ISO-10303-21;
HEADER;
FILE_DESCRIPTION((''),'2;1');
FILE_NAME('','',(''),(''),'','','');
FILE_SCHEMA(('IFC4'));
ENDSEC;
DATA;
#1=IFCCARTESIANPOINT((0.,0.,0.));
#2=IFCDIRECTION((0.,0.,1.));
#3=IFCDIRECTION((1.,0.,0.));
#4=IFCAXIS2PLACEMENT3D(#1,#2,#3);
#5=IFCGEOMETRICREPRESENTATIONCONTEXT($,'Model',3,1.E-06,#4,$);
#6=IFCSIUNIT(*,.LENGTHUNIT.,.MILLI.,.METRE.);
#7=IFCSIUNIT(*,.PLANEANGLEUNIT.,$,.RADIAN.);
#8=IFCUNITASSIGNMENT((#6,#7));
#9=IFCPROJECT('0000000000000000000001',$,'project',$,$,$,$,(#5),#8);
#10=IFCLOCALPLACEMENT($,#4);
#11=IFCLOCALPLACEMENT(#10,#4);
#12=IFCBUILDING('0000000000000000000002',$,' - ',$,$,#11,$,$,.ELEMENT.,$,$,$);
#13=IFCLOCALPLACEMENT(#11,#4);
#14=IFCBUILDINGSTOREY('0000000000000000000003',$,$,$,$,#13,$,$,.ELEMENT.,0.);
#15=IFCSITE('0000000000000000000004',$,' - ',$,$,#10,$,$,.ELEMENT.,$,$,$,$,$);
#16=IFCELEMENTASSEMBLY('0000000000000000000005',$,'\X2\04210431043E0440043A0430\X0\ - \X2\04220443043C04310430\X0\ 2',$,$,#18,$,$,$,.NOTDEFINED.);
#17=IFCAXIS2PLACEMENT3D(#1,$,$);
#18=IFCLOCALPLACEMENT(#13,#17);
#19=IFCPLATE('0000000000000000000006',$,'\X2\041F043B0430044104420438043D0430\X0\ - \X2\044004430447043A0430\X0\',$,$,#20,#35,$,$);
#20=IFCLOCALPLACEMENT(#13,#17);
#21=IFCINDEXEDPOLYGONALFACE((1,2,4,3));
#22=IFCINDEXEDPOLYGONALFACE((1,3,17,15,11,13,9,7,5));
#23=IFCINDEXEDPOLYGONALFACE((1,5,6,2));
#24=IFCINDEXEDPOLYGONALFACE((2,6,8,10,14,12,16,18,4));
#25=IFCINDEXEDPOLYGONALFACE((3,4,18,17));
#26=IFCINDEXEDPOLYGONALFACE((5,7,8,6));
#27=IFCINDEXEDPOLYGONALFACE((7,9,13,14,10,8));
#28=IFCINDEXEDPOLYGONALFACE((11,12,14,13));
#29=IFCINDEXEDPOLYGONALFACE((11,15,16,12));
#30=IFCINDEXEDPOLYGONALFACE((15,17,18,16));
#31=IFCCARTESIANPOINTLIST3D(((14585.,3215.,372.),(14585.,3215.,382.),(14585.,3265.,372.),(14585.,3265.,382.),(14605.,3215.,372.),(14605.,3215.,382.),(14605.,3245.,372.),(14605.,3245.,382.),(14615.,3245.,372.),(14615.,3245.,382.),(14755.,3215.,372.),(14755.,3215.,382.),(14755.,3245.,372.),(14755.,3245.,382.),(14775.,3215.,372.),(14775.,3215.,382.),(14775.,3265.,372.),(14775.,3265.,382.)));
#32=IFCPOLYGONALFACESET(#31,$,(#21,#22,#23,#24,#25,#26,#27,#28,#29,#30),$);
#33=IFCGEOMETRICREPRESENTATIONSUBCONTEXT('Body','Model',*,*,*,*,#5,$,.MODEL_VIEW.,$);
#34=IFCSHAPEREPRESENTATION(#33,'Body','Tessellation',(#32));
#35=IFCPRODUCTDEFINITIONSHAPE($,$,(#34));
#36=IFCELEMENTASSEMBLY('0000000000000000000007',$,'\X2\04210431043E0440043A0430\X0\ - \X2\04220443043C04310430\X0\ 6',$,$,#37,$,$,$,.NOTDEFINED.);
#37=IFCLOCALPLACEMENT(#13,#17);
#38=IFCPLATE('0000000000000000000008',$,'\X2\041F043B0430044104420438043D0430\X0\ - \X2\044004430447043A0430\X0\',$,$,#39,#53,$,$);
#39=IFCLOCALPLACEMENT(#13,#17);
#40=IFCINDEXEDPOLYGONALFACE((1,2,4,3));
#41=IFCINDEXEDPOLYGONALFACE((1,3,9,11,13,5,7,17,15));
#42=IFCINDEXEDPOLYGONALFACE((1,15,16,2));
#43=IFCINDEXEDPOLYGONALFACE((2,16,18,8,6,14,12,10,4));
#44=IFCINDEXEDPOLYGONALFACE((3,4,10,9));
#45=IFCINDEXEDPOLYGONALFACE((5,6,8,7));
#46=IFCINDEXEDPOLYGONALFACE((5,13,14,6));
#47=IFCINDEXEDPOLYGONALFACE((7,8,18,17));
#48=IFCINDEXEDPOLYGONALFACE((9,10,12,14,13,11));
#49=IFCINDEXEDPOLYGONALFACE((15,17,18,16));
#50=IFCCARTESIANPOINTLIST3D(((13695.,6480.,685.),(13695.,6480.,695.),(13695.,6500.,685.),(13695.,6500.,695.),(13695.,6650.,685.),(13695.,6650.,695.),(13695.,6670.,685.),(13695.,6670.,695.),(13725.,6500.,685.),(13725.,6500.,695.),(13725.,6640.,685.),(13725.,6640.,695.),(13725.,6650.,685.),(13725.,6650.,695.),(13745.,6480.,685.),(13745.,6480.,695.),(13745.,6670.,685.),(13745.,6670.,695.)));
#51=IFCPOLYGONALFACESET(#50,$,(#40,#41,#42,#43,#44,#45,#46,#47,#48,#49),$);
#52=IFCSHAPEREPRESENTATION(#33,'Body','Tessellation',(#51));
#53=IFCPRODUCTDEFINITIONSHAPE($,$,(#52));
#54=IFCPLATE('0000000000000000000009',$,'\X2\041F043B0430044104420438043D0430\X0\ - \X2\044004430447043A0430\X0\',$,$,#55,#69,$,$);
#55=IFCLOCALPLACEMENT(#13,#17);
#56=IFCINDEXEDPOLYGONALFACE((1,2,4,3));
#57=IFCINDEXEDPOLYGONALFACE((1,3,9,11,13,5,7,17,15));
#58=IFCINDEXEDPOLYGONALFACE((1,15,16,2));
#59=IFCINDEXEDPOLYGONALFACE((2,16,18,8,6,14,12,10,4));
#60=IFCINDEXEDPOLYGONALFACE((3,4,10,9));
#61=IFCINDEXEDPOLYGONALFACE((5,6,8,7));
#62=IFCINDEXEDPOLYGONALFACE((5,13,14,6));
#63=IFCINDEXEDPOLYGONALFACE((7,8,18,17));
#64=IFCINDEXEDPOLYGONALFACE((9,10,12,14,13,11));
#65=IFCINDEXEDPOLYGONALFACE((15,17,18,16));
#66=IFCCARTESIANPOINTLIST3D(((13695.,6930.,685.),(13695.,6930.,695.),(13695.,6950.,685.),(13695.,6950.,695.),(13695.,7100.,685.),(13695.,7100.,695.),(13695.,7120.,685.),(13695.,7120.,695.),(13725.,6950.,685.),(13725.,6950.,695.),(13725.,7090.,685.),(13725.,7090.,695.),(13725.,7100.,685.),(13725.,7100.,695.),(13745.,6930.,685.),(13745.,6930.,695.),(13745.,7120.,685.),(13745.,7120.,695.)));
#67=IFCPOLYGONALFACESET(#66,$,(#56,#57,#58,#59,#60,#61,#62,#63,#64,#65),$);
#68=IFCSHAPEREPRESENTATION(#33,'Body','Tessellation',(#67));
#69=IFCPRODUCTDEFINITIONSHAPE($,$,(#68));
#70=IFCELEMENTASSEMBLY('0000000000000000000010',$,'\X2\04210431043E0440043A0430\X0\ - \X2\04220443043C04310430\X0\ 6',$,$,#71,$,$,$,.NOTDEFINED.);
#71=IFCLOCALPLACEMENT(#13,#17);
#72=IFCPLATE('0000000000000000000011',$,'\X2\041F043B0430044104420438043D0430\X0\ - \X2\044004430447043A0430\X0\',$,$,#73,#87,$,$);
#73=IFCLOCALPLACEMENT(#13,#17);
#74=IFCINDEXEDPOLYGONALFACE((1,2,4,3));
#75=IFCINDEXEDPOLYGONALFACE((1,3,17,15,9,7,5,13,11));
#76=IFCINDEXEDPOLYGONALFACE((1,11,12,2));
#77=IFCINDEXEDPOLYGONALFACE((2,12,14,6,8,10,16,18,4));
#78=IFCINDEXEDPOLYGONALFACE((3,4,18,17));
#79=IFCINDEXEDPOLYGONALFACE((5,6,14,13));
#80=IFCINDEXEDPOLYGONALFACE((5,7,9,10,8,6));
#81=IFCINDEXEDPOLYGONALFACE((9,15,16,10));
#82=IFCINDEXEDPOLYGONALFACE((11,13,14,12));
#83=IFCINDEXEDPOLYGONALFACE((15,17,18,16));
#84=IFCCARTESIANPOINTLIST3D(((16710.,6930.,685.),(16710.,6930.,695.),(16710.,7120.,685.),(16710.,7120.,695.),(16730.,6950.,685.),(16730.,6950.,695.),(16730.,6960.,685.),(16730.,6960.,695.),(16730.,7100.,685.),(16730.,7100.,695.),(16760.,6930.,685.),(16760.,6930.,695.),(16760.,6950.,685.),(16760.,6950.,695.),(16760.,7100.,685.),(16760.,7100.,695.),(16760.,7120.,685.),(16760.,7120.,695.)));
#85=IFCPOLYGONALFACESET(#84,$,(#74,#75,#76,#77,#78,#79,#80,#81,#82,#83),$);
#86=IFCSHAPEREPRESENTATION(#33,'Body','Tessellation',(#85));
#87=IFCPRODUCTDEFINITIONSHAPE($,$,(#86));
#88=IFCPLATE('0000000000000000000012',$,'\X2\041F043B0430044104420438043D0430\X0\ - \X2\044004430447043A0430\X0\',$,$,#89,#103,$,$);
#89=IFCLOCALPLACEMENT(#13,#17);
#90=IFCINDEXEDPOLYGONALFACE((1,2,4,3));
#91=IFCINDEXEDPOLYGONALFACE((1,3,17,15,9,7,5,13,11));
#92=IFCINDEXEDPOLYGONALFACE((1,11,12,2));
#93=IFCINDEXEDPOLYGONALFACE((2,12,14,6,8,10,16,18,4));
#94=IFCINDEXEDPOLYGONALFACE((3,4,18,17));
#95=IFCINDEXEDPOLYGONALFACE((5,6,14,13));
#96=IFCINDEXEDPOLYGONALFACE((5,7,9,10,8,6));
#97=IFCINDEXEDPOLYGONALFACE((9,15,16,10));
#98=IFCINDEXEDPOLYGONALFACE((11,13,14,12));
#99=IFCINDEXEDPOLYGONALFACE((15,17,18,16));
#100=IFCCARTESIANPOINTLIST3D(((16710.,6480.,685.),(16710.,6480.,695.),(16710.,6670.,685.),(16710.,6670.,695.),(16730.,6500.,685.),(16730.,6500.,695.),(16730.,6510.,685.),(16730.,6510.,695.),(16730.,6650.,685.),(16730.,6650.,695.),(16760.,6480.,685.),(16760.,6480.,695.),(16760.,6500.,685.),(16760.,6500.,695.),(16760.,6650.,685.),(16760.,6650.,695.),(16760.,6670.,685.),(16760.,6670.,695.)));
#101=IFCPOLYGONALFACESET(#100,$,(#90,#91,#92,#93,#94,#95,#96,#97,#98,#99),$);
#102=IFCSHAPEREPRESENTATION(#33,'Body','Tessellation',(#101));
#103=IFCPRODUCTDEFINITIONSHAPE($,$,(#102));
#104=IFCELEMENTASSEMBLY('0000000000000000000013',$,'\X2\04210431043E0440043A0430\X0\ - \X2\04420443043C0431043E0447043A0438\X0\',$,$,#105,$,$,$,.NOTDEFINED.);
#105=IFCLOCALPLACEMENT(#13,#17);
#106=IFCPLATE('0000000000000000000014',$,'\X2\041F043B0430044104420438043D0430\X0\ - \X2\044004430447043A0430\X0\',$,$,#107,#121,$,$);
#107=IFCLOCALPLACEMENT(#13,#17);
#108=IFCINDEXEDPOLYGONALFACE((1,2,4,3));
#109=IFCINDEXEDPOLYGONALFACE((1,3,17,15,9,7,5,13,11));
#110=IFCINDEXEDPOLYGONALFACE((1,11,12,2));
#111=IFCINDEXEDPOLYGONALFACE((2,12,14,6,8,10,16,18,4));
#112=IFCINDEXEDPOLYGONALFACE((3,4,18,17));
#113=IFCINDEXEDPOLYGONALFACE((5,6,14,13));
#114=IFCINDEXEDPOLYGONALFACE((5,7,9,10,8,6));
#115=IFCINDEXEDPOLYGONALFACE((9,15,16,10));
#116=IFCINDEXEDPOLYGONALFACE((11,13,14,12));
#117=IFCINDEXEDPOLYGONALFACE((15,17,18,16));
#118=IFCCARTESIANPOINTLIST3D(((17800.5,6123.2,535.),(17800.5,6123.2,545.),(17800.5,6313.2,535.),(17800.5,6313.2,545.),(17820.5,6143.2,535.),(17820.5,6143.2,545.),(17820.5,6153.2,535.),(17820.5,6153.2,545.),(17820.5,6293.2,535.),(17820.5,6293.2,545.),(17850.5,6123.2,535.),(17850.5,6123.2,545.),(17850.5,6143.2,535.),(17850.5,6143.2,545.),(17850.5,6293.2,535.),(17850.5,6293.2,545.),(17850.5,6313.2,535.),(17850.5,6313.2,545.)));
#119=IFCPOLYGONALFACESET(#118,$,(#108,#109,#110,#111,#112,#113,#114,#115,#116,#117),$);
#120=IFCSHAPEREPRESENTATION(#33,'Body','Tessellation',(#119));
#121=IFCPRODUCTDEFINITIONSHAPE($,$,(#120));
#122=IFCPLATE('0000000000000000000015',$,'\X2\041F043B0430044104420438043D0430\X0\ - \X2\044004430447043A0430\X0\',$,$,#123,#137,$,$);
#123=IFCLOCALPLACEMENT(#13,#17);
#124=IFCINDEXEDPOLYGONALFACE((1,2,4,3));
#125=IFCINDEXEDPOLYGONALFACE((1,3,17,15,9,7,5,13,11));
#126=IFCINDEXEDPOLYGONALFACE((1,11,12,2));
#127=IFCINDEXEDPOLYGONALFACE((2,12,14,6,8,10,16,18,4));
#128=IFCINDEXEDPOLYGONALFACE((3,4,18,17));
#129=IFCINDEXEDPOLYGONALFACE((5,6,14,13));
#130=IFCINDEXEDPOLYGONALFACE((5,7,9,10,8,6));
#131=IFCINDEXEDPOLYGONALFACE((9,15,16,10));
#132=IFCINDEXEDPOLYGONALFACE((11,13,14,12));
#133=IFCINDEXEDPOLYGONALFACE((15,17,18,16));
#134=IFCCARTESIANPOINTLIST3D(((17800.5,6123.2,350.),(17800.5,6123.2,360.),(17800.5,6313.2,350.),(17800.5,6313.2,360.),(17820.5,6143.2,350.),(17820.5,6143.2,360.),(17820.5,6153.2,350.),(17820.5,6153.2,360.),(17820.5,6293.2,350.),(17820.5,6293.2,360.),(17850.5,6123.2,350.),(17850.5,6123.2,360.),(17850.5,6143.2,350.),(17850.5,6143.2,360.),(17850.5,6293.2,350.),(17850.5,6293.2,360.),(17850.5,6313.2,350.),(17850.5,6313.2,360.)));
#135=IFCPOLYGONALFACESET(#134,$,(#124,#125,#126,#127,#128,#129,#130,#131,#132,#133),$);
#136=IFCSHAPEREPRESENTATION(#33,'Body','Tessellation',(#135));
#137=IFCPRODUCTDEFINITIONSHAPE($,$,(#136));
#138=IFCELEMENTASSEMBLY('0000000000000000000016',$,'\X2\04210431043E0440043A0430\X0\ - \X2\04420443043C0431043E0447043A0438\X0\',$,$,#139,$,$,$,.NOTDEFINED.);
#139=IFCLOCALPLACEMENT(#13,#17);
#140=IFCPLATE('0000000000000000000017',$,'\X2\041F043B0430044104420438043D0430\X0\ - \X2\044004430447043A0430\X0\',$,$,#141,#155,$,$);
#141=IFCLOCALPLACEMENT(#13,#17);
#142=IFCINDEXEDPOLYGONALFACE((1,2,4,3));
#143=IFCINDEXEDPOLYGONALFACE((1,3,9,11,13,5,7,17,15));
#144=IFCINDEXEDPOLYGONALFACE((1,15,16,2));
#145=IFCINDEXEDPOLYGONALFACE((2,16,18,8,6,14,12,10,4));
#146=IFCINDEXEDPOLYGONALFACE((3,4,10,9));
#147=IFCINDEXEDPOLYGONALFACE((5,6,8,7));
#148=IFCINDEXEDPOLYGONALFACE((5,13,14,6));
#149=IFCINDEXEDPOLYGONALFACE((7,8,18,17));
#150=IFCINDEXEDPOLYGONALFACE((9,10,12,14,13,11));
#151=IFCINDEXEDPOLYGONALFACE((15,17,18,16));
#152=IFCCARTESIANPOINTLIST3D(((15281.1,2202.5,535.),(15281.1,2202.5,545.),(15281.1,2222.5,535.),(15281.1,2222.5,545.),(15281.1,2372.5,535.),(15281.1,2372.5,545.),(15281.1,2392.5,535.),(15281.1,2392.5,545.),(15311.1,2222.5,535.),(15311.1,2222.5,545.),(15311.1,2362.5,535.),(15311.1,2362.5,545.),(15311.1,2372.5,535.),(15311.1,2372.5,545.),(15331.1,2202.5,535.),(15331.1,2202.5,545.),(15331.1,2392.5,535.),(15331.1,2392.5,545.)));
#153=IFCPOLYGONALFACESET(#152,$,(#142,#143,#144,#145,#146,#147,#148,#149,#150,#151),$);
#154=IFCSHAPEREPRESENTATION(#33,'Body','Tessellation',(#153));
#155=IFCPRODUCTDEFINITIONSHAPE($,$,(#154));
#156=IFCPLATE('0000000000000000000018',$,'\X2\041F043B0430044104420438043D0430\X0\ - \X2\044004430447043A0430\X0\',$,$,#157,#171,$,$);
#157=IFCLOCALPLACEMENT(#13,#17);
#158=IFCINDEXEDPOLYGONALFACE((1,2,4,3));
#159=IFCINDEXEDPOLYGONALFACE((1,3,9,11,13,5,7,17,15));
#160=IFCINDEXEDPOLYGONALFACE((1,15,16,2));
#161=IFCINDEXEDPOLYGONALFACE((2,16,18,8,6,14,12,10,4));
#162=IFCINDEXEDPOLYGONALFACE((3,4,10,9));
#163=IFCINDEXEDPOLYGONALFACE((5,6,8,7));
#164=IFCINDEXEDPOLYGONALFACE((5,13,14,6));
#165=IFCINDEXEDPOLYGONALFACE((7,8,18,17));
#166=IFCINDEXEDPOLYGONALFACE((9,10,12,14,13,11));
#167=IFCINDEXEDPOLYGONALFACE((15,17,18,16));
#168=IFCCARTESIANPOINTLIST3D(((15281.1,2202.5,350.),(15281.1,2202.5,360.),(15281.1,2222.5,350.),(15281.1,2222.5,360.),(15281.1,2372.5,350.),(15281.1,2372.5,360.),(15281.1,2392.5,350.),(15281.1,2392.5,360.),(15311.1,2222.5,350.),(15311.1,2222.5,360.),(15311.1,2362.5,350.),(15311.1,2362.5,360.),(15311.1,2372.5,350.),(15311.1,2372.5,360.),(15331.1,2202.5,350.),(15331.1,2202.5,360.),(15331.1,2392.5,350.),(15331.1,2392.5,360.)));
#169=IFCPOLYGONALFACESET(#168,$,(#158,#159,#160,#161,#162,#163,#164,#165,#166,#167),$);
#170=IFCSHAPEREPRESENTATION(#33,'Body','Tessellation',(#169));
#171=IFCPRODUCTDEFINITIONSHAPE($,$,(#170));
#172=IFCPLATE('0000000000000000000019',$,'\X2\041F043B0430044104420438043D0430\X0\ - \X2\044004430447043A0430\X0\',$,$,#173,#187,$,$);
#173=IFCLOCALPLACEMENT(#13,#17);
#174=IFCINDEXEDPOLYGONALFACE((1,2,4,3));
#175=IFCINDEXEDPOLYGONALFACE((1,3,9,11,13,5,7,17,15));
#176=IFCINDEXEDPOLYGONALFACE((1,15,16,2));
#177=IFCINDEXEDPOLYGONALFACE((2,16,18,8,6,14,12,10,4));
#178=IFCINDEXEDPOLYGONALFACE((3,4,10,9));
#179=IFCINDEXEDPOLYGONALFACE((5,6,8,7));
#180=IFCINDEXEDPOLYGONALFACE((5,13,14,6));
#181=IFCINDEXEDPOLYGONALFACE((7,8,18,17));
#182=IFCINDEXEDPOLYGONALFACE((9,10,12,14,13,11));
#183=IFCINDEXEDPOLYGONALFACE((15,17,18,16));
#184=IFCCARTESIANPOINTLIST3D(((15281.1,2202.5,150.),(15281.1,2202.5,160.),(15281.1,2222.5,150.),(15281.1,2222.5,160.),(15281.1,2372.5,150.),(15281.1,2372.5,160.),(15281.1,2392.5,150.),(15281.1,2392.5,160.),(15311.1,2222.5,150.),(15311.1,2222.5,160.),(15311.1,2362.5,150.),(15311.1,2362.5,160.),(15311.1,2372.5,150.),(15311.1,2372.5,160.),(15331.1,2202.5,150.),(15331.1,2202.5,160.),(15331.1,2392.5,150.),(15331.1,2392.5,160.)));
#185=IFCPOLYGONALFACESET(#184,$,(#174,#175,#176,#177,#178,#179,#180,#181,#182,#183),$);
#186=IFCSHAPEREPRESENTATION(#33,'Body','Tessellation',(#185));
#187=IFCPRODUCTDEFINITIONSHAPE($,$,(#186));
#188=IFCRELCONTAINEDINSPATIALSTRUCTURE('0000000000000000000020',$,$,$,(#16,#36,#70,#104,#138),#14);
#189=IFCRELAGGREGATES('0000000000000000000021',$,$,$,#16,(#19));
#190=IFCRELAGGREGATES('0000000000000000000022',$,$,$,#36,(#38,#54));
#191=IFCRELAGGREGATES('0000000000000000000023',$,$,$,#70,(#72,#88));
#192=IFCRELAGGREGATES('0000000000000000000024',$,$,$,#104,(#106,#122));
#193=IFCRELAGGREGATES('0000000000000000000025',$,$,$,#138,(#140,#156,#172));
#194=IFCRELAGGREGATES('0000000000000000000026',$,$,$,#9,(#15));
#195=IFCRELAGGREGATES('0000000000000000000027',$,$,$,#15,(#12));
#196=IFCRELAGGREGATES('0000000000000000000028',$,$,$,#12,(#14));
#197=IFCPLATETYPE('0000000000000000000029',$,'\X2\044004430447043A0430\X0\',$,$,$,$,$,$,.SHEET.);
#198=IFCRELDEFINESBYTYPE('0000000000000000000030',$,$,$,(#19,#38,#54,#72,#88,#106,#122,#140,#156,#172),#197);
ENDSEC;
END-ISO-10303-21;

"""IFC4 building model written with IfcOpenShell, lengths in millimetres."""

from ifc_helpers import new_model, si_unit, frame, origin_with_axes, place, context, subcontext, project, spatial, line, indexed_curve, outline, extrude, source, transform, mapped, type_object, element, aggregate, save


model = new_model("IFC4")

# Units and contexts
model_context = context("Model", 3, precision=1e-06, world=origin_with_axes())
body_context = subcontext(model_context, "Body", "Model", "MODEL_VIEW")
ifc_project = project(units=[si_unit("LENGTHUNIT", "METRE", prefix="MILLI"), si_unit("PLANEANGLEUNIT", "RADIAN")], contexts=[model_context])

# Site, building, storey
site_placement = place(None, origin_with_axes())
site = spatial("IfcSite", under=ifc_project, at=site_placement, Name=" - ", CompositionType="ELEMENT")
building_placement = place(site_placement, origin_with_axes())
building = spatial("IfcBuilding", under=site, at=building_placement, Name=" - ", CompositionType="ELEMENT")
storey_placement = place(building_placement, origin_with_axes())
storey = spatial("IfcBuildingStorey", under=building, at=storey_placement, CompositionType="ELEMENT", Elevation=0.0)

# Element assembly, plate
assembly_1_placement = place(storey_placement, frame((14680.0, 3000.0, 2.0), z_axis=(0.0, 0.0, 1.0), x_axis=(-1.0, 0.0, 0.0)))
assembly_1 = element("IfcElementAssembly", 1, at=assembly_1_placement, inside=storey, Name="Сборка - Тумба 2", PredefinedType="NOTDEFINED")
plate_type = type_object("IfcPlateType", Name="ручка", PredefinedType="SHEET")
shared_shape = source(origin_with_axes(), body_context, "Body", "SweptSolid", [
    extrude(outline(indexed_curve([(-95.0, -25.0), (-75.0, -25.0), (-75.0, 5.0), (-65.0, 5.0), (75.0, 5.0), (75.0, -25.0), (95.0, -25.0), (95.0, 25.0), (-95.0, 25.0)], segments=[line(1, 2), line(2, 3), line(3, 4), line(4, 5), line(5, 6), line(6, 7), line(7, 8), line(8, 9), line(9, 1)])), origin_with_axes(), (0.0, 0.0, 1.0), 10.0),
])
plate_1_placement = place(assembly_1_placement, frame((0.0, -240.0, 370.0), z_axis=(0.0, 0.0, 1.0), x_axis=(-1.0, 0.0, 0.0)))
plate_1 = element("IfcPlate", 2, at=plate_1_placement, type_object=plate_type, Name="Пластина - ручка", context=body_context, shape_type="MappedRepresentation", body=[
    mapped(shared_shape, transform((0.0, 0.0, 0.0), x_axis=(1.0, 0.0, 0.0), y_axis=(0.0, 1.0, 0.0), z_axis=(0.0, 0.0, 1.0), scale=1.0)),
])
aggregate(assembly_1, [plate_1])

# Element assemblies, plates
assembly_2_placement = place(storey_placement, frame((13680.0, 6350.0, 0.0), z_axis=(0.0, 0.0, 1.0), x_axis=(0.0, 1.0, 0.0)))
assembly_2 = element("IfcElementAssembly", 3, at=assembly_2_placement, inside=storey, Name="Сборка - Тумба 6", PredefinedType="NOTDEFINED")
plate_2_placement = place(assembly_2_placement, frame((225.0, -40.0, 685.0), z_axis=(0.0, 0.0, 1.0), x_axis=(-1.0, 0.0, 0.0)))
plate_2 = element("IfcPlate", 4, at=plate_2_placement, type_object=plate_type, Name="Пластина - ручка", context=body_context, shape_type="MappedRepresentation", body=[
    mapped(shared_shape, transform((0.0, 0.0, 0.0), x_axis=(1.0, 0.0, 0.0), y_axis=(0.0, 1.0, 0.0), z_axis=(0.0, 0.0, 1.0), scale=1.0)),
])
plate_3_placement = place(assembly_2_placement, frame((675.0, -40.0, 685.0), z_axis=(0.0, 0.0, 1.0), x_axis=(-1.0, 0.0, 0.0)))
plate_3 = element("IfcPlate", 5, at=plate_3_placement, type_object=plate_type, Name="Пластина - ручка", context=body_context, shape_type="MappedRepresentation", body=[
    mapped(shared_shape, transform((0.0, 0.0, 0.0), x_axis=(1.0, 0.0, 0.0), y_axis=(0.0, 1.0, 0.0), z_axis=(0.0, 0.0, 1.0), scale=1.0)),
])
aggregate(assembly_2, [plate_2, plate_3])
assembly_3_placement = place(storey_placement, frame((16775.0, 7250.0, 0.0), z_axis=(0.0, 0.0, 1.0), x_axis=(0.0, -1.0, 0.0)))
assembly_3 = element("IfcElementAssembly", 6, at=assembly_3_placement, inside=storey, Name="Сборка - Тумба 6", PredefinedType="NOTDEFINED")
plate_4_placement = place(assembly_3_placement, frame((225.0, -40.0, 685.0), z_axis=(0.0, 0.0, 1.0), x_axis=(-1.0, 0.0, 0.0)))
plate_4 = element("IfcPlate", 7, at=plate_4_placement, type_object=plate_type, Name="Пластина - ручка", context=body_context, shape_type="MappedRepresentation", body=[
    mapped(shared_shape, transform((0.0, 0.0, 0.0), x_axis=(1.0, 0.0, 0.0), y_axis=(0.0, 1.0, 0.0), z_axis=(0.0, 0.0, 1.0), scale=1.0)),
])
plate_5_placement = place(assembly_3_placement, frame((675.0, -40.0, 685.0), z_axis=(0.0, 0.0, 1.0), x_axis=(-1.0, 0.0, 0.0)))
plate_5 = element("IfcPlate", 8, at=plate_5_placement, type_object=plate_type, Name="Пластина - ручка", context=body_context, shape_type="MappedRepresentation", body=[
    mapped(shared_shape, transform((0.0, 0.0, 0.0), x_axis=(1.0, 0.0, 0.0), y_axis=(0.0, 1.0, 0.0), z_axis=(0.0, 0.0, 1.0), scale=1.0)),
])
aggregate(assembly_3, [plate_4, plate_5])
assembly_4_placement = place(storey_placement, frame((17850.5, 6418.2, 0.0), z_axis=(0.0, 0.0, 1.0), x_axis=(0.0, -1.0, 0.0)))
assembly_4 = element("IfcElementAssembly", 9, at=assembly_4_placement, inside=storey, Name="Сборка - тумбочки", PredefinedType="NOTDEFINED")
plate_6_placement = place(assembly_4_placement, frame((200.0, -25.0, 535.0), z_axis=(0.0, 0.0, 1.0), x_axis=(-1.0, 0.0, 0.0)))
plate_6 = element("IfcPlate", 10, at=plate_6_placement, type_object=plate_type, Name="Пластина - ручка", context=body_context, shape_type="MappedRepresentation", body=[
    mapped(shared_shape, transform((0.0, 0.0, 0.0), x_axis=(1.0, 0.0, 0.0), y_axis=(0.0, 1.0, 0.0), z_axis=(0.0, 0.0, 1.0), scale=1.0)),
])
plate_7_placement = place(assembly_4_placement, frame((200.0, -25.0, 350.0), z_axis=(0.0, 0.0, 1.0), x_axis=(-1.0, 0.0, 0.0)))
plate_7 = element("IfcPlate", 11, at=plate_7_placement, type_object=plate_type, Name="Пластина - ручка", context=body_context, shape_type="MappedRepresentation", body=[
    mapped(shared_shape, transform((0.0, 0.0, 0.0), x_axis=(1.0, 0.0, 0.0), y_axis=(0.0, 1.0, 0.0), z_axis=(0.0, 0.0, 1.0), scale=1.0)),
])
aggregate(assembly_4, [plate_6, plate_7])
assembly_5_placement = place(storey_placement, frame((15281.1, 2097.5, 0.0), z_axis=(0.0, 0.0, 1.0), x_axis=(0.0, 1.0, 0.0)))
assembly_5 = element("IfcElementAssembly", 12, at=assembly_5_placement, inside=storey, Name="Сборка - тумбочки", PredefinedType="NOTDEFINED")
plate_8_placement = place(assembly_5_placement, frame((200.0, -25.0, 535.0), z_axis=(0.0, 0.0, 1.0), x_axis=(-1.0, 0.0, 0.0)))
plate_8 = element("IfcPlate", 13, at=plate_8_placement, type_object=plate_type, Name="Пластина - ручка", context=body_context, shape_type="MappedRepresentation", body=[
    mapped(shared_shape, transform((0.0, 0.0, 0.0), x_axis=(1.0, 0.0, 0.0), y_axis=(0.0, 1.0, 0.0), z_axis=(0.0, 0.0, 1.0), scale=1.0)),
])
plate_9_placement = place(assembly_5_placement, frame((200.0, -25.0, 350.0), z_axis=(0.0, 0.0, 1.0), x_axis=(-1.0, 0.0, 0.0)))
plate_9 = element("IfcPlate", 14, at=plate_9_placement, type_object=plate_type, Name="Пластина - ручка", context=body_context, shape_type="MappedRepresentation", body=[
    mapped(shared_shape, transform((0.0, 0.0, 0.0), x_axis=(1.0, 0.0, 0.0), y_axis=(0.0, 1.0, 0.0), z_axis=(0.0, 0.0, 1.0), scale=1.0)),
])
plate_10_placement = place(assembly_5_placement, frame((200.0, -25.0, 150.0), z_axis=(0.0, 0.0, 1.0), x_axis=(-1.0, 0.0, 0.0)))
plate_10 = element("IfcPlate", 15, at=plate_10_placement, type_object=plate_type, Name="Пластина - ручка", context=body_context, shape_type="MappedRepresentation", body=[
    mapped(shared_shape, transform((0.0, 0.0, 0.0), x_axis=(1.0, 0.0, 0.0), y_axis=(0.0, 1.0, 0.0), z_axis=(0.0, 0.0, 1.0), scale=1.0)),
])
aggregate(assembly_5, [plate_8, plate_9, plate_10])

save(model, "model.ifc")
